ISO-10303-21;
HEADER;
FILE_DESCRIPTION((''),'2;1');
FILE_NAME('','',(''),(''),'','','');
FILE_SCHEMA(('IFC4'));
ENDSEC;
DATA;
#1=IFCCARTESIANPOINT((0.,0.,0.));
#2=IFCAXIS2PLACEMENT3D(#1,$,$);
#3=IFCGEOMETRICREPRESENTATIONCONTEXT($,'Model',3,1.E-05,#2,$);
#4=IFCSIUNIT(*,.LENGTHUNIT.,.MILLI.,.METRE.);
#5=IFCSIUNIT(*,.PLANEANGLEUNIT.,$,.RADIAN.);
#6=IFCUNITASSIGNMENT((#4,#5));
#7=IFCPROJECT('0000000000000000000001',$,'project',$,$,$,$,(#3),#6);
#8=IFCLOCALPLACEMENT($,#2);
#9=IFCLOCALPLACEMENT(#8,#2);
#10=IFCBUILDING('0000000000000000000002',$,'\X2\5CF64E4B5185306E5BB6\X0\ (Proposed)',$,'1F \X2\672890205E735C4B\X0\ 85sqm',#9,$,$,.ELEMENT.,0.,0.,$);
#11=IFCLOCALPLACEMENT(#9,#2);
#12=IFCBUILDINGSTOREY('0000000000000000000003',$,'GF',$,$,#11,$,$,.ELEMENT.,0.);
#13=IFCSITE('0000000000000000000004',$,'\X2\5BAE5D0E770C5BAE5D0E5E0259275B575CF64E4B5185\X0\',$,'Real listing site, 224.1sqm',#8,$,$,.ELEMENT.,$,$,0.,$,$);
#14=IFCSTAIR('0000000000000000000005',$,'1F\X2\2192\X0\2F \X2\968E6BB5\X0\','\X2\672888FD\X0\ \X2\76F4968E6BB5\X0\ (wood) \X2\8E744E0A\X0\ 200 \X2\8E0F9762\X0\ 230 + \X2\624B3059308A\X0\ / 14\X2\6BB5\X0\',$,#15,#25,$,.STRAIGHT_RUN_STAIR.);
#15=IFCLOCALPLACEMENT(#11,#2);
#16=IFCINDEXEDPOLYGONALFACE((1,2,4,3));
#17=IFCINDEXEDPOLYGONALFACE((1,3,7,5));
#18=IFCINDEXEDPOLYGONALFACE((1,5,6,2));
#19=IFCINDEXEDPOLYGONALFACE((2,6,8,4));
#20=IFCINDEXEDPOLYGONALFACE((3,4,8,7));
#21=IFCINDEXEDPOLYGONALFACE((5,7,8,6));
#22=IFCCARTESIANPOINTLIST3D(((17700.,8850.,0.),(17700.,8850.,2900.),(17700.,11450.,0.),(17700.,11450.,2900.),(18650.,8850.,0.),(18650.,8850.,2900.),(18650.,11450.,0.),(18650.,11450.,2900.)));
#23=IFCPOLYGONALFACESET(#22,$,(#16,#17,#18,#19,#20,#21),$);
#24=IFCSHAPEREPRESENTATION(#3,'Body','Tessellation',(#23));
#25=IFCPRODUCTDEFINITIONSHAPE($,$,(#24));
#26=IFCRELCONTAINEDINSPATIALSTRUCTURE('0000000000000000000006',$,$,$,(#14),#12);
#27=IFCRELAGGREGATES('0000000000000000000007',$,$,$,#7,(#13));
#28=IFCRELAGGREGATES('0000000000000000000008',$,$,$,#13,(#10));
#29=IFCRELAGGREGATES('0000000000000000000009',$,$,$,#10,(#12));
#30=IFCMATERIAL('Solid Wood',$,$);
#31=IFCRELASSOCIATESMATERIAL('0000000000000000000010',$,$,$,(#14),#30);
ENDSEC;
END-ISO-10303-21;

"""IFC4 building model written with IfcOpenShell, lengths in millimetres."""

from ifc_helpers import new_model, si_unit, frame, frame_2d, origin, place, context, project, spatial, rectangle, extrude, material, element, save


model = new_model("IFC4")

# Units and contexts
model_context = context("Model", 3, precision=1e-05, world=origin())
ifc_project = project(units=[si_unit("LENGTHUNIT", "METRE", prefix="MILLI"), si_unit("PLANEANGLEUNIT", "RADIAN")], contexts=[model_context])

# Site, building, storey
site_placement = place(None, origin())
site = spatial("IfcSite", under=ifc_project, at=site_placement, Name="宮崎県宮崎市大字島之内", ObjectType="Real listing site, 224.1sqm", CompositionType="ELEMENT", RefElevation=0.0)
building_placement = place(site_placement, origin())
building = spatial("IfcBuilding", under=site, at=building_placement, Name="島之内の家 (Proposed)", ObjectType="1F 木造平屋 85sqm", CompositionType="ELEMENT", ElevationOfRefHeight=0.0, ElevationOfTerrain=0.0)
storey_placement = place(building_placement, origin())
storey = spatial("IfcBuildingStorey", under=building, at=storey_placement, Name="GF", CompositionType="ELEMENT", Elevation=0.0)

# Shared definitions
ifc_material_1 = material(Name="Solid Wood")

# Stair
stair_placement = place(storey_placement, frame((8850.0, 4425.0, 0.0)))
element("IfcStair", 1, at=stair_placement, inside=storey, material=ifc_material_1, Name="1F→2F 階段", Description="木製 直階段 (wood) 蹴上 200 踏面 230 + 手すり / 14段", PredefinedType="STRAIGHT_RUN_STAIR", context=model_context, shape_type="SweptSolid", body=[
    extrude(rectangle(XDim=950.0, YDim=2600.0, at=frame_2d((475.0, 1300.0))), frame((8850.0, 4425.0, 0.0)), (0.0, 0.0, 1.0), 2900.0),
])

save(model, "model.ifc")
